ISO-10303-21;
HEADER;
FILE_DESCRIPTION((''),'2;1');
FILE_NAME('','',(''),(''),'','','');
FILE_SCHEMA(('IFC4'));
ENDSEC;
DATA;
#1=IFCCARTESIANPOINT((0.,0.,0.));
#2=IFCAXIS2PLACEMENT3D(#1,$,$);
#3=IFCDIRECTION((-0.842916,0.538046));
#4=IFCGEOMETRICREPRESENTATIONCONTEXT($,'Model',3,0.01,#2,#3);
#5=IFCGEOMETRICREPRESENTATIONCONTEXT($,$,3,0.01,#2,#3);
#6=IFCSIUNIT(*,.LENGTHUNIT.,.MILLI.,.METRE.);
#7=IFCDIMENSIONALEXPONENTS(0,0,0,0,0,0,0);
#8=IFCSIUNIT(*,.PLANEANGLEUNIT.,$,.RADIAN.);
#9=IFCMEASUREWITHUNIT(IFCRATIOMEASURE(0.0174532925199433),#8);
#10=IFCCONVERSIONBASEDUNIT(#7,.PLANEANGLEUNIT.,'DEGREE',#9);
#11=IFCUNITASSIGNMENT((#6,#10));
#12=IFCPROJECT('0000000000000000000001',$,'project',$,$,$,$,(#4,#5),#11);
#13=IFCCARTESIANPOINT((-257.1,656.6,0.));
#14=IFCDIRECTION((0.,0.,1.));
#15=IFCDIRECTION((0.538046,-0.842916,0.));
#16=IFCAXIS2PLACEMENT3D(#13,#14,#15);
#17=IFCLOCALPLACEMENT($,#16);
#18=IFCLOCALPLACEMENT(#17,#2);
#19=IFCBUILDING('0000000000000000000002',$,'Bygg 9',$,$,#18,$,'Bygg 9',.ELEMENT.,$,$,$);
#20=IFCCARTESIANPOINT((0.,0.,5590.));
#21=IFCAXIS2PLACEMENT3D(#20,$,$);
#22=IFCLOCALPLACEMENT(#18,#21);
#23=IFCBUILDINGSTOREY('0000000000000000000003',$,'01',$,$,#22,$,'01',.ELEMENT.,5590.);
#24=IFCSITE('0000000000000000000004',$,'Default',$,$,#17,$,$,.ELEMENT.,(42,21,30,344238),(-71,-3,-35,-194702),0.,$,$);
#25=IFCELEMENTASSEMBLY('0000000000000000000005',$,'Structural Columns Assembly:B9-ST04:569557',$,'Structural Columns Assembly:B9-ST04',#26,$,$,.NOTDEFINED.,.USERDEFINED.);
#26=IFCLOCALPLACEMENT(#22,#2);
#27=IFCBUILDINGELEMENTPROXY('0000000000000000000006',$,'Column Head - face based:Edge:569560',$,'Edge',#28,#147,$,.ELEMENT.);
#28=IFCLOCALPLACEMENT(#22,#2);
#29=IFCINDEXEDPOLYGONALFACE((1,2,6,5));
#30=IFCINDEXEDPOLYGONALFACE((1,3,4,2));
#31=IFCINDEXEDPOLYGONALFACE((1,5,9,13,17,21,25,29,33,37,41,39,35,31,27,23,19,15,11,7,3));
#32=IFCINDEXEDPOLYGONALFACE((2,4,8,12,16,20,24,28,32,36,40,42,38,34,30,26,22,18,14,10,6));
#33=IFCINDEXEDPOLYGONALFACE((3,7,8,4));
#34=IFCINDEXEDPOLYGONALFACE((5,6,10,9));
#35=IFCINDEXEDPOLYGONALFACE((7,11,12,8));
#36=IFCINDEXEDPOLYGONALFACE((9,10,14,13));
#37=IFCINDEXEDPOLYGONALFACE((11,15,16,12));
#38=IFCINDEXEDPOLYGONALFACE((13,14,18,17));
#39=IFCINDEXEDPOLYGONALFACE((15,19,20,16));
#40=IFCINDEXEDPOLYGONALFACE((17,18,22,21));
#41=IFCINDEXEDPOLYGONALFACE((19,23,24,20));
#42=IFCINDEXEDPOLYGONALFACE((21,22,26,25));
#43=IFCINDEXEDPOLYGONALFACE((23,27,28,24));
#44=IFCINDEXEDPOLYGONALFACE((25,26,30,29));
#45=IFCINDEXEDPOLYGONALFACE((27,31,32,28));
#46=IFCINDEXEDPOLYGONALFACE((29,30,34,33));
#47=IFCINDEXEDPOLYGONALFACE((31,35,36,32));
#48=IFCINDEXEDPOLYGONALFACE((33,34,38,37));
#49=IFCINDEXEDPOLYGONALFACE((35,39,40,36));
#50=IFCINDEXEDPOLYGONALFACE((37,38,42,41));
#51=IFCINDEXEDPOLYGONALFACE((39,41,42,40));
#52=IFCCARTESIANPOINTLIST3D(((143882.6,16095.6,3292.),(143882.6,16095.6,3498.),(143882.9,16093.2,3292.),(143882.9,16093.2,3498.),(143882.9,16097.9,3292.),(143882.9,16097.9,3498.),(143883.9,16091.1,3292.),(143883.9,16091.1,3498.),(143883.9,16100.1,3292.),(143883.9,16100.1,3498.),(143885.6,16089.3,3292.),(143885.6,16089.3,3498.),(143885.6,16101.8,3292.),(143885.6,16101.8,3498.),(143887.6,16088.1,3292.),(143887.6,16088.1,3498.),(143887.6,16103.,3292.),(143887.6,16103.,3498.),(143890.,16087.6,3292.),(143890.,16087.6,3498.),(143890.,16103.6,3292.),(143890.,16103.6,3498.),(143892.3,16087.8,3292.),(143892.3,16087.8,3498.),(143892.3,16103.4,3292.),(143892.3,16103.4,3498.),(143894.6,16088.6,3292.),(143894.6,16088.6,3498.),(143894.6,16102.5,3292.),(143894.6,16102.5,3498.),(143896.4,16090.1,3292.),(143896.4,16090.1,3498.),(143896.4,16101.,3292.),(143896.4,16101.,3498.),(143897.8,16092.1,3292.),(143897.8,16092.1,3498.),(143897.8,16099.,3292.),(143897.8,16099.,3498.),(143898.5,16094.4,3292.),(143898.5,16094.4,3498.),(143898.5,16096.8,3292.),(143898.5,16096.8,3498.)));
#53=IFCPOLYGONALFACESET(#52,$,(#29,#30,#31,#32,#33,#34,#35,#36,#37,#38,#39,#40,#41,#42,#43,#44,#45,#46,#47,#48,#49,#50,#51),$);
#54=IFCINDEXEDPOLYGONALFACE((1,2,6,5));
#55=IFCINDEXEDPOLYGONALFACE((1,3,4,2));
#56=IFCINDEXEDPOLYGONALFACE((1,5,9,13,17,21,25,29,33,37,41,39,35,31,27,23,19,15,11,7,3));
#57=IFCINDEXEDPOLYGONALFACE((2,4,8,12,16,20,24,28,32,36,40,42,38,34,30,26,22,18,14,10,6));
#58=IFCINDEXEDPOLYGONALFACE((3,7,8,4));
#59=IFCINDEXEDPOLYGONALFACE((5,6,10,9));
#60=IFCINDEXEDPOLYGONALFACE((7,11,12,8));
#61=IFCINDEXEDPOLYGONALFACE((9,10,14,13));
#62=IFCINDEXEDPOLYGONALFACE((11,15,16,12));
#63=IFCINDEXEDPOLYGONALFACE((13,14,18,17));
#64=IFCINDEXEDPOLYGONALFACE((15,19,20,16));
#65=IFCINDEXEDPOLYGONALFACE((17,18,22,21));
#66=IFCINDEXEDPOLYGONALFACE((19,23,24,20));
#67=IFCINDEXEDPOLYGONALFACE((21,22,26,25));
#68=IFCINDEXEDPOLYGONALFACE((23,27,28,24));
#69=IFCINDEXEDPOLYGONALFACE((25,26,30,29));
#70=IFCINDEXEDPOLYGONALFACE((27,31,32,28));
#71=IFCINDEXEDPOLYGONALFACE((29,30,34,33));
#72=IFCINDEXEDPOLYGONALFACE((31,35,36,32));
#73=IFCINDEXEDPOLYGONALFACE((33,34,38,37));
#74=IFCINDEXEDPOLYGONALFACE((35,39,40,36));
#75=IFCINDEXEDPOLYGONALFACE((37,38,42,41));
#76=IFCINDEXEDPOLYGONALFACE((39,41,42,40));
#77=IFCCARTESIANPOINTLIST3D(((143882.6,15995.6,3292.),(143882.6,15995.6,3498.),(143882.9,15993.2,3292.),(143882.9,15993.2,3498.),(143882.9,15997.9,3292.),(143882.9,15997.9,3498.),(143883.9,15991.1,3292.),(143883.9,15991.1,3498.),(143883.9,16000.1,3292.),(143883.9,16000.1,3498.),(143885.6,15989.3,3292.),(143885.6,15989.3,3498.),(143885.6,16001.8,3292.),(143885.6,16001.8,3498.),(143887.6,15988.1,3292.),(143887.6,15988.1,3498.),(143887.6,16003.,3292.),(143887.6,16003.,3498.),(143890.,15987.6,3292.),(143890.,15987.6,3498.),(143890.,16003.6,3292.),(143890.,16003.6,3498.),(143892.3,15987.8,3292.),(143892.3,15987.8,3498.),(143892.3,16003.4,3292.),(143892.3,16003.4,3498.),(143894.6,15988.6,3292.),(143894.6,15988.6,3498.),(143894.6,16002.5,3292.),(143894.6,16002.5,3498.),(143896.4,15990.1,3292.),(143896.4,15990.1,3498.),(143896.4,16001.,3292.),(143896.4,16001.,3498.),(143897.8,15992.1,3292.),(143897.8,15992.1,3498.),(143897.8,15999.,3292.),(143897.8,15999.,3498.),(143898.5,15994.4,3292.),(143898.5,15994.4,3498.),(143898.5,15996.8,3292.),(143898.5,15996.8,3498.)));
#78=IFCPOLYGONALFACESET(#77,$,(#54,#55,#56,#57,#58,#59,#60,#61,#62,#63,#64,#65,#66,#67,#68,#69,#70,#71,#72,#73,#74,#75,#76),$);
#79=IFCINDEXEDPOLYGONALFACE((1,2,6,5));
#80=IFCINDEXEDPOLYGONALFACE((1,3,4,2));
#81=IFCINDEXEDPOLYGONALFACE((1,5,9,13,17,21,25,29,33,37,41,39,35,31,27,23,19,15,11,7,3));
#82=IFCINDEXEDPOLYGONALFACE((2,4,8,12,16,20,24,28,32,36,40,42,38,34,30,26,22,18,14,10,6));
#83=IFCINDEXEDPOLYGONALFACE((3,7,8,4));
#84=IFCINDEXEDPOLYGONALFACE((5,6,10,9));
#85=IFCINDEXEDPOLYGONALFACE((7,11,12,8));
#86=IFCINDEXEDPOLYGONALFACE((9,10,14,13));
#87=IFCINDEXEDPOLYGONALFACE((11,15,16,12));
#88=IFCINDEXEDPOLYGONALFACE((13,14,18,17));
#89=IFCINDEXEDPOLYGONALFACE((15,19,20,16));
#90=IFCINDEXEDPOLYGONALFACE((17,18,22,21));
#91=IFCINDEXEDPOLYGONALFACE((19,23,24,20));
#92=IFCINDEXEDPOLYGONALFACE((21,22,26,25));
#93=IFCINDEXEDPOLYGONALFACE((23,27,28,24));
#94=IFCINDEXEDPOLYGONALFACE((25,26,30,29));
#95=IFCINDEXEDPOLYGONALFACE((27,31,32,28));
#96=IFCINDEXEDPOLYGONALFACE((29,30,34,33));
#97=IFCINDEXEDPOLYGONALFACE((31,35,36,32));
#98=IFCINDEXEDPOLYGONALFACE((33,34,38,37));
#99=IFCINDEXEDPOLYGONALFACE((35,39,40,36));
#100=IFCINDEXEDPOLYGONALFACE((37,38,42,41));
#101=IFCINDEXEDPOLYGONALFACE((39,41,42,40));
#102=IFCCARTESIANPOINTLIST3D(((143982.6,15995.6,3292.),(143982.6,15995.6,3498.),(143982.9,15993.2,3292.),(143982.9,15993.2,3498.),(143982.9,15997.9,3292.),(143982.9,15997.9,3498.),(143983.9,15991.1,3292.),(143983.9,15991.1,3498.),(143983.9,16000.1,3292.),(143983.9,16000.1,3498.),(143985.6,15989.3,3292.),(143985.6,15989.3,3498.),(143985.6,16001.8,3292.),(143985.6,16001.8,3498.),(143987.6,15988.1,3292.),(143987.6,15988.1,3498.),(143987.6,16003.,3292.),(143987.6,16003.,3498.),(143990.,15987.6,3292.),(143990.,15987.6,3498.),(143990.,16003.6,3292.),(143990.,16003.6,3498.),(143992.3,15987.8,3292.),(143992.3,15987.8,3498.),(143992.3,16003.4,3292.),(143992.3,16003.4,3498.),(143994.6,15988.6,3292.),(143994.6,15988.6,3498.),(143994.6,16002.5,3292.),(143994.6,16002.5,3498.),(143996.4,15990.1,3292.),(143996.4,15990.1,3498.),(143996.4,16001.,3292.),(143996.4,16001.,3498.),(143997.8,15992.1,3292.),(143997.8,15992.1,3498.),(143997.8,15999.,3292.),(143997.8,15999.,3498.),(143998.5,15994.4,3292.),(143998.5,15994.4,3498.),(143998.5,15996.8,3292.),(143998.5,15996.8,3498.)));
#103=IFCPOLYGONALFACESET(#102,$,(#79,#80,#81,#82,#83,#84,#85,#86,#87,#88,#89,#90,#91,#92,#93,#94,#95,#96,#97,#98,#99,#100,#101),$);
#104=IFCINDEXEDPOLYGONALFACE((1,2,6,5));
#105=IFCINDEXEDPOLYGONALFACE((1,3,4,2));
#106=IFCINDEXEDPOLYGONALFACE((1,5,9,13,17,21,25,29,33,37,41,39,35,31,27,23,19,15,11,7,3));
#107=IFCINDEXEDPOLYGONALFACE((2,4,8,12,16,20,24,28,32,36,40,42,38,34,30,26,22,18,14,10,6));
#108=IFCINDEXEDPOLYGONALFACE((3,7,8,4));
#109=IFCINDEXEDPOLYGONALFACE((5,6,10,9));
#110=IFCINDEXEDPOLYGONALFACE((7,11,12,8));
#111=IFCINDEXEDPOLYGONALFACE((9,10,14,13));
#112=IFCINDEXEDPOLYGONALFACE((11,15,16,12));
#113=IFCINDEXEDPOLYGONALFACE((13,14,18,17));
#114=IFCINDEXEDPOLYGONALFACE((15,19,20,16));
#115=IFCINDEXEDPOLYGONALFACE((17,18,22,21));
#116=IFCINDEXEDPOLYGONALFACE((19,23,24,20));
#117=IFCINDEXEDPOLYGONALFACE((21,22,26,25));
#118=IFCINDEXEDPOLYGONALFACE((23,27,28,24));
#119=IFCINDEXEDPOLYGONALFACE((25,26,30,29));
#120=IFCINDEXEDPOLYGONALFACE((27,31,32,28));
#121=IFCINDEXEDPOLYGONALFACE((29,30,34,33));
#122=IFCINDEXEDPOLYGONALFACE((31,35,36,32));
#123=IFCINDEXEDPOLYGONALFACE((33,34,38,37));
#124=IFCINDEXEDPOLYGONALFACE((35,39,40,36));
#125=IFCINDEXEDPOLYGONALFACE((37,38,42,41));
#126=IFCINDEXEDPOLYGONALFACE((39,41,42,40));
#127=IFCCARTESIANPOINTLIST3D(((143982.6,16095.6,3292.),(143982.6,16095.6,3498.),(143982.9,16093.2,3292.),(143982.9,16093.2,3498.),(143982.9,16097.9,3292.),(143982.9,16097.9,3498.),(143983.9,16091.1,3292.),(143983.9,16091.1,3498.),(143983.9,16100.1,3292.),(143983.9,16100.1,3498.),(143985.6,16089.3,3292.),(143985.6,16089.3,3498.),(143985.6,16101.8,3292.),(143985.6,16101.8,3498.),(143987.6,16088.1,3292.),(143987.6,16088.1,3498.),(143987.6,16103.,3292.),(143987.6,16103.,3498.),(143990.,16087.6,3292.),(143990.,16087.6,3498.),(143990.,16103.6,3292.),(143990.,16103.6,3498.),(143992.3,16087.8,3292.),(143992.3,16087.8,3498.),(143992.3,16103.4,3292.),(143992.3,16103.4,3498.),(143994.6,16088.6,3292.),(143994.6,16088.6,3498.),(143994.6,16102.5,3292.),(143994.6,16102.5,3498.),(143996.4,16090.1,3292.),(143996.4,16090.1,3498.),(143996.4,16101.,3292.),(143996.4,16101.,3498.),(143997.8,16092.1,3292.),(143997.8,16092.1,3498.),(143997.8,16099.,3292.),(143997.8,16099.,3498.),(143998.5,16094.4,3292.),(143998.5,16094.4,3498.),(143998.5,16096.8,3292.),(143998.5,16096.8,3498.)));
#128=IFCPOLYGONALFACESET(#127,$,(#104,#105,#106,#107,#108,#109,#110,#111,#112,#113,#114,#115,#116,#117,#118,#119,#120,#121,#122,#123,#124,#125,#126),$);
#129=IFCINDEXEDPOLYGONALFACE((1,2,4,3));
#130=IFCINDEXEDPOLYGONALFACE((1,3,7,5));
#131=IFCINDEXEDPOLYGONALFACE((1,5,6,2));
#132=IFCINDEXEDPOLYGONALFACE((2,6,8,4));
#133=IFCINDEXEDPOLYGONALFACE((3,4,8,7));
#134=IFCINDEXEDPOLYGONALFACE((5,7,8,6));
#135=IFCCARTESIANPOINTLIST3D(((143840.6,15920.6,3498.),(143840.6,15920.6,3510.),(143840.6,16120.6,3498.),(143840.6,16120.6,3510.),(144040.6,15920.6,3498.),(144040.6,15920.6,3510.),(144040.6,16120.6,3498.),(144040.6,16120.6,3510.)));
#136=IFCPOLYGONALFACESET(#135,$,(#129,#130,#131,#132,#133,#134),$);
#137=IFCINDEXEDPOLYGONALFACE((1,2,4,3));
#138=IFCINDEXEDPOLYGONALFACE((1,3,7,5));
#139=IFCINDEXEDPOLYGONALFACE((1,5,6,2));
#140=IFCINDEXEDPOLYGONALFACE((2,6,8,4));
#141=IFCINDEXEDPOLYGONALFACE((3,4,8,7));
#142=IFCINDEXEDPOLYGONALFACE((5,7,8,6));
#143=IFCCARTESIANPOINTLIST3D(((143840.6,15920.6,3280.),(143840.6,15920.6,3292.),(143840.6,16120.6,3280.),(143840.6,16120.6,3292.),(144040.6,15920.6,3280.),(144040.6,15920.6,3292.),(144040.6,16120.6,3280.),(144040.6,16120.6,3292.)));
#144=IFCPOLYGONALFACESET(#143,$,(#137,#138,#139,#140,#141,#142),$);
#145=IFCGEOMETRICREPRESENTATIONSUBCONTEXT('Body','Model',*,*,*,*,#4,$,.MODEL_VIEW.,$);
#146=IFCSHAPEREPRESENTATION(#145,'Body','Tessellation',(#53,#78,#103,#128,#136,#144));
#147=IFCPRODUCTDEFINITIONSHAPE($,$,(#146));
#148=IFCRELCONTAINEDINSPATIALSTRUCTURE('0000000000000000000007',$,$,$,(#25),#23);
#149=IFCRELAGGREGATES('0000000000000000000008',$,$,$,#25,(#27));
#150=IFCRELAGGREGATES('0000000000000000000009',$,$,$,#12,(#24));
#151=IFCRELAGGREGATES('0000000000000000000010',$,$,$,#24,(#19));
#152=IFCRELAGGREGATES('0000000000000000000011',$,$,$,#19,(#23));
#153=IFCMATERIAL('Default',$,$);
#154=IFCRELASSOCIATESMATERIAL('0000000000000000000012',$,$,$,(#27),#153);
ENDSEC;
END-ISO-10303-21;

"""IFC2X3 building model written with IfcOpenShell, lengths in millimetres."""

from ifc_helpers import new_model, entity, si_unit, converted_unit, direction, frame, frame_2d, origin, origin_2d_with_axis, place, context, subcontext, project, spatial, rectangle, circle, extrude, source, transform, mapped, material, element, aggregate, save


model = new_model("IFC2X3")

# Units and contexts
model_context = context("Model", 3, precision=0.01, world=origin(), true_north=direction((-0.842916, 0.538046)))
context_of_model = context(None, 3, precision=0.01, world=origin(), true_north=direction((-0.842916, 0.538046)))
body_context = subcontext(model_context, "Body", "Model", "MODEL_VIEW")
ifc_project = project(units=[si_unit("LENGTHUNIT", "METRE", prefix="MILLI"), converted_unit("PLANEANGLEUNIT", "DEGREE", entity("IfcRatioMeasure", 0.0174532925199433), si_unit("PLANEANGLEUNIT", "RADIAN"), dimensions=[0, 0, 0, 0, 0, 0, 0])], contexts=[model_context, context_of_model])

# Site, building, storey
site_placement = place(None, frame((-257.1, 656.6, 0.0), z_axis=(0.0, 0.0, 1.0), x_axis=(0.538046, -0.842916, 0.0)))
site = spatial("IfcSite", under=ifc_project, at=site_placement, Name="Default", CompositionType="ELEMENT", RefLatitude=(42, 21, 30, 344238), RefLongitude=(-71, -3, -35, -194702), RefElevation=0.0)
building_placement = place(site_placement, origin())
building = spatial("IfcBuilding", under=site, at=building_placement, Name="Bygg 9", LongName="Bygg 9", CompositionType="ELEMENT")
storey_placement = place(building_placement, frame((0.0, 0.0, 5590.0)))
storey = spatial("IfcBuildingStorey", under=building, at=storey_placement, Name="01", LongName="01", CompositionType="ELEMENT", Elevation=5590.0)

# Element assembly
assembly_1_placement = place(storey_placement, origin())
assembly_1 = element("IfcElementAssembly", 1, at=assembly_1_placement, inside=storey, Name="Structural Columns Assembly:B9-ST04:569557", ObjectType="Structural Columns Assembly:B9-ST04", AssemblyPlace="NOTDEFINED", PredefinedType="USERDEFINED")

# Building element proxy
ifc_material_1 = material(Name="Default")
shared_shape_1 = source(origin(), body_context, "Body", "SweptSolid", [
    extrude(circle(Radius=8.0, at=frame_2d((0.0, 0.0), x_axis=(1.0, 0.0))), frame((50.0, -75.0, 12.0)), (0.0, 0.0, 1.0), 206.0),
    extrude(circle(Radius=8.0, at=frame_2d((0.0, 0.0), x_axis=(1.0, 0.0))), frame((50.0, 25.0, 12.0)), (0.0, 0.0, 1.0), 206.0),
    extrude(circle(Radius=8.0, at=frame_2d((0.0, 0.0), x_axis=(1.0, 0.0))), frame((-50.0, 25.0, 12.0)), (0.0, 0.0, 1.0), 206.0),
    extrude(circle(Radius=8.0, at=frame_2d((0.0, 0.0), x_axis=(1.0, 0.0))), frame((-50.0, -75.0, 12.0)), (0.0, 0.0, 1.0), 206.0),
    extrude(rectangle(XDim=200.0, YDim=200.0, at=origin_2d_with_axis()), frame((0.0, 0.0, 218.0), z_axis=(0.0, 0.0, 1.0), x_axis=(-1.0, 0.0, 0.0)), (0.0, 0.0, 1.0), 12.0),
    extrude(rectangle(XDim=200.0, YDim=200.0, at=origin_2d_with_axis()), frame((0.0, 0.0, 0.0), z_axis=(0.0, 0.0, 1.0), x_axis=(0.0, 1.0, 0.0)), (0.0, 0.0, 1.0), 12.0),
])
proxy_1_placement = place(assembly_1_placement, frame((143940.6, 16020.6, 3280.0), z_axis=(0.0, 0.0, 1.0), x_axis=(-1.0, 0.0, 0.0)))
proxy_1 = element("IfcBuildingElementProxy", 2, at=proxy_1_placement, material=ifc_material_1, Name="Column Head - face based:Edge:569560", ObjectType="Edge", CompositionType="ELEMENT", context=body_context, shape_type="MappedRepresentation", body=[
    mapped(shared_shape_1, transform((0.0, 0.0, 0.0), scale=1.0)),
])
aggregate(assembly_1, [proxy_1])

save(model, "model.ifc")
